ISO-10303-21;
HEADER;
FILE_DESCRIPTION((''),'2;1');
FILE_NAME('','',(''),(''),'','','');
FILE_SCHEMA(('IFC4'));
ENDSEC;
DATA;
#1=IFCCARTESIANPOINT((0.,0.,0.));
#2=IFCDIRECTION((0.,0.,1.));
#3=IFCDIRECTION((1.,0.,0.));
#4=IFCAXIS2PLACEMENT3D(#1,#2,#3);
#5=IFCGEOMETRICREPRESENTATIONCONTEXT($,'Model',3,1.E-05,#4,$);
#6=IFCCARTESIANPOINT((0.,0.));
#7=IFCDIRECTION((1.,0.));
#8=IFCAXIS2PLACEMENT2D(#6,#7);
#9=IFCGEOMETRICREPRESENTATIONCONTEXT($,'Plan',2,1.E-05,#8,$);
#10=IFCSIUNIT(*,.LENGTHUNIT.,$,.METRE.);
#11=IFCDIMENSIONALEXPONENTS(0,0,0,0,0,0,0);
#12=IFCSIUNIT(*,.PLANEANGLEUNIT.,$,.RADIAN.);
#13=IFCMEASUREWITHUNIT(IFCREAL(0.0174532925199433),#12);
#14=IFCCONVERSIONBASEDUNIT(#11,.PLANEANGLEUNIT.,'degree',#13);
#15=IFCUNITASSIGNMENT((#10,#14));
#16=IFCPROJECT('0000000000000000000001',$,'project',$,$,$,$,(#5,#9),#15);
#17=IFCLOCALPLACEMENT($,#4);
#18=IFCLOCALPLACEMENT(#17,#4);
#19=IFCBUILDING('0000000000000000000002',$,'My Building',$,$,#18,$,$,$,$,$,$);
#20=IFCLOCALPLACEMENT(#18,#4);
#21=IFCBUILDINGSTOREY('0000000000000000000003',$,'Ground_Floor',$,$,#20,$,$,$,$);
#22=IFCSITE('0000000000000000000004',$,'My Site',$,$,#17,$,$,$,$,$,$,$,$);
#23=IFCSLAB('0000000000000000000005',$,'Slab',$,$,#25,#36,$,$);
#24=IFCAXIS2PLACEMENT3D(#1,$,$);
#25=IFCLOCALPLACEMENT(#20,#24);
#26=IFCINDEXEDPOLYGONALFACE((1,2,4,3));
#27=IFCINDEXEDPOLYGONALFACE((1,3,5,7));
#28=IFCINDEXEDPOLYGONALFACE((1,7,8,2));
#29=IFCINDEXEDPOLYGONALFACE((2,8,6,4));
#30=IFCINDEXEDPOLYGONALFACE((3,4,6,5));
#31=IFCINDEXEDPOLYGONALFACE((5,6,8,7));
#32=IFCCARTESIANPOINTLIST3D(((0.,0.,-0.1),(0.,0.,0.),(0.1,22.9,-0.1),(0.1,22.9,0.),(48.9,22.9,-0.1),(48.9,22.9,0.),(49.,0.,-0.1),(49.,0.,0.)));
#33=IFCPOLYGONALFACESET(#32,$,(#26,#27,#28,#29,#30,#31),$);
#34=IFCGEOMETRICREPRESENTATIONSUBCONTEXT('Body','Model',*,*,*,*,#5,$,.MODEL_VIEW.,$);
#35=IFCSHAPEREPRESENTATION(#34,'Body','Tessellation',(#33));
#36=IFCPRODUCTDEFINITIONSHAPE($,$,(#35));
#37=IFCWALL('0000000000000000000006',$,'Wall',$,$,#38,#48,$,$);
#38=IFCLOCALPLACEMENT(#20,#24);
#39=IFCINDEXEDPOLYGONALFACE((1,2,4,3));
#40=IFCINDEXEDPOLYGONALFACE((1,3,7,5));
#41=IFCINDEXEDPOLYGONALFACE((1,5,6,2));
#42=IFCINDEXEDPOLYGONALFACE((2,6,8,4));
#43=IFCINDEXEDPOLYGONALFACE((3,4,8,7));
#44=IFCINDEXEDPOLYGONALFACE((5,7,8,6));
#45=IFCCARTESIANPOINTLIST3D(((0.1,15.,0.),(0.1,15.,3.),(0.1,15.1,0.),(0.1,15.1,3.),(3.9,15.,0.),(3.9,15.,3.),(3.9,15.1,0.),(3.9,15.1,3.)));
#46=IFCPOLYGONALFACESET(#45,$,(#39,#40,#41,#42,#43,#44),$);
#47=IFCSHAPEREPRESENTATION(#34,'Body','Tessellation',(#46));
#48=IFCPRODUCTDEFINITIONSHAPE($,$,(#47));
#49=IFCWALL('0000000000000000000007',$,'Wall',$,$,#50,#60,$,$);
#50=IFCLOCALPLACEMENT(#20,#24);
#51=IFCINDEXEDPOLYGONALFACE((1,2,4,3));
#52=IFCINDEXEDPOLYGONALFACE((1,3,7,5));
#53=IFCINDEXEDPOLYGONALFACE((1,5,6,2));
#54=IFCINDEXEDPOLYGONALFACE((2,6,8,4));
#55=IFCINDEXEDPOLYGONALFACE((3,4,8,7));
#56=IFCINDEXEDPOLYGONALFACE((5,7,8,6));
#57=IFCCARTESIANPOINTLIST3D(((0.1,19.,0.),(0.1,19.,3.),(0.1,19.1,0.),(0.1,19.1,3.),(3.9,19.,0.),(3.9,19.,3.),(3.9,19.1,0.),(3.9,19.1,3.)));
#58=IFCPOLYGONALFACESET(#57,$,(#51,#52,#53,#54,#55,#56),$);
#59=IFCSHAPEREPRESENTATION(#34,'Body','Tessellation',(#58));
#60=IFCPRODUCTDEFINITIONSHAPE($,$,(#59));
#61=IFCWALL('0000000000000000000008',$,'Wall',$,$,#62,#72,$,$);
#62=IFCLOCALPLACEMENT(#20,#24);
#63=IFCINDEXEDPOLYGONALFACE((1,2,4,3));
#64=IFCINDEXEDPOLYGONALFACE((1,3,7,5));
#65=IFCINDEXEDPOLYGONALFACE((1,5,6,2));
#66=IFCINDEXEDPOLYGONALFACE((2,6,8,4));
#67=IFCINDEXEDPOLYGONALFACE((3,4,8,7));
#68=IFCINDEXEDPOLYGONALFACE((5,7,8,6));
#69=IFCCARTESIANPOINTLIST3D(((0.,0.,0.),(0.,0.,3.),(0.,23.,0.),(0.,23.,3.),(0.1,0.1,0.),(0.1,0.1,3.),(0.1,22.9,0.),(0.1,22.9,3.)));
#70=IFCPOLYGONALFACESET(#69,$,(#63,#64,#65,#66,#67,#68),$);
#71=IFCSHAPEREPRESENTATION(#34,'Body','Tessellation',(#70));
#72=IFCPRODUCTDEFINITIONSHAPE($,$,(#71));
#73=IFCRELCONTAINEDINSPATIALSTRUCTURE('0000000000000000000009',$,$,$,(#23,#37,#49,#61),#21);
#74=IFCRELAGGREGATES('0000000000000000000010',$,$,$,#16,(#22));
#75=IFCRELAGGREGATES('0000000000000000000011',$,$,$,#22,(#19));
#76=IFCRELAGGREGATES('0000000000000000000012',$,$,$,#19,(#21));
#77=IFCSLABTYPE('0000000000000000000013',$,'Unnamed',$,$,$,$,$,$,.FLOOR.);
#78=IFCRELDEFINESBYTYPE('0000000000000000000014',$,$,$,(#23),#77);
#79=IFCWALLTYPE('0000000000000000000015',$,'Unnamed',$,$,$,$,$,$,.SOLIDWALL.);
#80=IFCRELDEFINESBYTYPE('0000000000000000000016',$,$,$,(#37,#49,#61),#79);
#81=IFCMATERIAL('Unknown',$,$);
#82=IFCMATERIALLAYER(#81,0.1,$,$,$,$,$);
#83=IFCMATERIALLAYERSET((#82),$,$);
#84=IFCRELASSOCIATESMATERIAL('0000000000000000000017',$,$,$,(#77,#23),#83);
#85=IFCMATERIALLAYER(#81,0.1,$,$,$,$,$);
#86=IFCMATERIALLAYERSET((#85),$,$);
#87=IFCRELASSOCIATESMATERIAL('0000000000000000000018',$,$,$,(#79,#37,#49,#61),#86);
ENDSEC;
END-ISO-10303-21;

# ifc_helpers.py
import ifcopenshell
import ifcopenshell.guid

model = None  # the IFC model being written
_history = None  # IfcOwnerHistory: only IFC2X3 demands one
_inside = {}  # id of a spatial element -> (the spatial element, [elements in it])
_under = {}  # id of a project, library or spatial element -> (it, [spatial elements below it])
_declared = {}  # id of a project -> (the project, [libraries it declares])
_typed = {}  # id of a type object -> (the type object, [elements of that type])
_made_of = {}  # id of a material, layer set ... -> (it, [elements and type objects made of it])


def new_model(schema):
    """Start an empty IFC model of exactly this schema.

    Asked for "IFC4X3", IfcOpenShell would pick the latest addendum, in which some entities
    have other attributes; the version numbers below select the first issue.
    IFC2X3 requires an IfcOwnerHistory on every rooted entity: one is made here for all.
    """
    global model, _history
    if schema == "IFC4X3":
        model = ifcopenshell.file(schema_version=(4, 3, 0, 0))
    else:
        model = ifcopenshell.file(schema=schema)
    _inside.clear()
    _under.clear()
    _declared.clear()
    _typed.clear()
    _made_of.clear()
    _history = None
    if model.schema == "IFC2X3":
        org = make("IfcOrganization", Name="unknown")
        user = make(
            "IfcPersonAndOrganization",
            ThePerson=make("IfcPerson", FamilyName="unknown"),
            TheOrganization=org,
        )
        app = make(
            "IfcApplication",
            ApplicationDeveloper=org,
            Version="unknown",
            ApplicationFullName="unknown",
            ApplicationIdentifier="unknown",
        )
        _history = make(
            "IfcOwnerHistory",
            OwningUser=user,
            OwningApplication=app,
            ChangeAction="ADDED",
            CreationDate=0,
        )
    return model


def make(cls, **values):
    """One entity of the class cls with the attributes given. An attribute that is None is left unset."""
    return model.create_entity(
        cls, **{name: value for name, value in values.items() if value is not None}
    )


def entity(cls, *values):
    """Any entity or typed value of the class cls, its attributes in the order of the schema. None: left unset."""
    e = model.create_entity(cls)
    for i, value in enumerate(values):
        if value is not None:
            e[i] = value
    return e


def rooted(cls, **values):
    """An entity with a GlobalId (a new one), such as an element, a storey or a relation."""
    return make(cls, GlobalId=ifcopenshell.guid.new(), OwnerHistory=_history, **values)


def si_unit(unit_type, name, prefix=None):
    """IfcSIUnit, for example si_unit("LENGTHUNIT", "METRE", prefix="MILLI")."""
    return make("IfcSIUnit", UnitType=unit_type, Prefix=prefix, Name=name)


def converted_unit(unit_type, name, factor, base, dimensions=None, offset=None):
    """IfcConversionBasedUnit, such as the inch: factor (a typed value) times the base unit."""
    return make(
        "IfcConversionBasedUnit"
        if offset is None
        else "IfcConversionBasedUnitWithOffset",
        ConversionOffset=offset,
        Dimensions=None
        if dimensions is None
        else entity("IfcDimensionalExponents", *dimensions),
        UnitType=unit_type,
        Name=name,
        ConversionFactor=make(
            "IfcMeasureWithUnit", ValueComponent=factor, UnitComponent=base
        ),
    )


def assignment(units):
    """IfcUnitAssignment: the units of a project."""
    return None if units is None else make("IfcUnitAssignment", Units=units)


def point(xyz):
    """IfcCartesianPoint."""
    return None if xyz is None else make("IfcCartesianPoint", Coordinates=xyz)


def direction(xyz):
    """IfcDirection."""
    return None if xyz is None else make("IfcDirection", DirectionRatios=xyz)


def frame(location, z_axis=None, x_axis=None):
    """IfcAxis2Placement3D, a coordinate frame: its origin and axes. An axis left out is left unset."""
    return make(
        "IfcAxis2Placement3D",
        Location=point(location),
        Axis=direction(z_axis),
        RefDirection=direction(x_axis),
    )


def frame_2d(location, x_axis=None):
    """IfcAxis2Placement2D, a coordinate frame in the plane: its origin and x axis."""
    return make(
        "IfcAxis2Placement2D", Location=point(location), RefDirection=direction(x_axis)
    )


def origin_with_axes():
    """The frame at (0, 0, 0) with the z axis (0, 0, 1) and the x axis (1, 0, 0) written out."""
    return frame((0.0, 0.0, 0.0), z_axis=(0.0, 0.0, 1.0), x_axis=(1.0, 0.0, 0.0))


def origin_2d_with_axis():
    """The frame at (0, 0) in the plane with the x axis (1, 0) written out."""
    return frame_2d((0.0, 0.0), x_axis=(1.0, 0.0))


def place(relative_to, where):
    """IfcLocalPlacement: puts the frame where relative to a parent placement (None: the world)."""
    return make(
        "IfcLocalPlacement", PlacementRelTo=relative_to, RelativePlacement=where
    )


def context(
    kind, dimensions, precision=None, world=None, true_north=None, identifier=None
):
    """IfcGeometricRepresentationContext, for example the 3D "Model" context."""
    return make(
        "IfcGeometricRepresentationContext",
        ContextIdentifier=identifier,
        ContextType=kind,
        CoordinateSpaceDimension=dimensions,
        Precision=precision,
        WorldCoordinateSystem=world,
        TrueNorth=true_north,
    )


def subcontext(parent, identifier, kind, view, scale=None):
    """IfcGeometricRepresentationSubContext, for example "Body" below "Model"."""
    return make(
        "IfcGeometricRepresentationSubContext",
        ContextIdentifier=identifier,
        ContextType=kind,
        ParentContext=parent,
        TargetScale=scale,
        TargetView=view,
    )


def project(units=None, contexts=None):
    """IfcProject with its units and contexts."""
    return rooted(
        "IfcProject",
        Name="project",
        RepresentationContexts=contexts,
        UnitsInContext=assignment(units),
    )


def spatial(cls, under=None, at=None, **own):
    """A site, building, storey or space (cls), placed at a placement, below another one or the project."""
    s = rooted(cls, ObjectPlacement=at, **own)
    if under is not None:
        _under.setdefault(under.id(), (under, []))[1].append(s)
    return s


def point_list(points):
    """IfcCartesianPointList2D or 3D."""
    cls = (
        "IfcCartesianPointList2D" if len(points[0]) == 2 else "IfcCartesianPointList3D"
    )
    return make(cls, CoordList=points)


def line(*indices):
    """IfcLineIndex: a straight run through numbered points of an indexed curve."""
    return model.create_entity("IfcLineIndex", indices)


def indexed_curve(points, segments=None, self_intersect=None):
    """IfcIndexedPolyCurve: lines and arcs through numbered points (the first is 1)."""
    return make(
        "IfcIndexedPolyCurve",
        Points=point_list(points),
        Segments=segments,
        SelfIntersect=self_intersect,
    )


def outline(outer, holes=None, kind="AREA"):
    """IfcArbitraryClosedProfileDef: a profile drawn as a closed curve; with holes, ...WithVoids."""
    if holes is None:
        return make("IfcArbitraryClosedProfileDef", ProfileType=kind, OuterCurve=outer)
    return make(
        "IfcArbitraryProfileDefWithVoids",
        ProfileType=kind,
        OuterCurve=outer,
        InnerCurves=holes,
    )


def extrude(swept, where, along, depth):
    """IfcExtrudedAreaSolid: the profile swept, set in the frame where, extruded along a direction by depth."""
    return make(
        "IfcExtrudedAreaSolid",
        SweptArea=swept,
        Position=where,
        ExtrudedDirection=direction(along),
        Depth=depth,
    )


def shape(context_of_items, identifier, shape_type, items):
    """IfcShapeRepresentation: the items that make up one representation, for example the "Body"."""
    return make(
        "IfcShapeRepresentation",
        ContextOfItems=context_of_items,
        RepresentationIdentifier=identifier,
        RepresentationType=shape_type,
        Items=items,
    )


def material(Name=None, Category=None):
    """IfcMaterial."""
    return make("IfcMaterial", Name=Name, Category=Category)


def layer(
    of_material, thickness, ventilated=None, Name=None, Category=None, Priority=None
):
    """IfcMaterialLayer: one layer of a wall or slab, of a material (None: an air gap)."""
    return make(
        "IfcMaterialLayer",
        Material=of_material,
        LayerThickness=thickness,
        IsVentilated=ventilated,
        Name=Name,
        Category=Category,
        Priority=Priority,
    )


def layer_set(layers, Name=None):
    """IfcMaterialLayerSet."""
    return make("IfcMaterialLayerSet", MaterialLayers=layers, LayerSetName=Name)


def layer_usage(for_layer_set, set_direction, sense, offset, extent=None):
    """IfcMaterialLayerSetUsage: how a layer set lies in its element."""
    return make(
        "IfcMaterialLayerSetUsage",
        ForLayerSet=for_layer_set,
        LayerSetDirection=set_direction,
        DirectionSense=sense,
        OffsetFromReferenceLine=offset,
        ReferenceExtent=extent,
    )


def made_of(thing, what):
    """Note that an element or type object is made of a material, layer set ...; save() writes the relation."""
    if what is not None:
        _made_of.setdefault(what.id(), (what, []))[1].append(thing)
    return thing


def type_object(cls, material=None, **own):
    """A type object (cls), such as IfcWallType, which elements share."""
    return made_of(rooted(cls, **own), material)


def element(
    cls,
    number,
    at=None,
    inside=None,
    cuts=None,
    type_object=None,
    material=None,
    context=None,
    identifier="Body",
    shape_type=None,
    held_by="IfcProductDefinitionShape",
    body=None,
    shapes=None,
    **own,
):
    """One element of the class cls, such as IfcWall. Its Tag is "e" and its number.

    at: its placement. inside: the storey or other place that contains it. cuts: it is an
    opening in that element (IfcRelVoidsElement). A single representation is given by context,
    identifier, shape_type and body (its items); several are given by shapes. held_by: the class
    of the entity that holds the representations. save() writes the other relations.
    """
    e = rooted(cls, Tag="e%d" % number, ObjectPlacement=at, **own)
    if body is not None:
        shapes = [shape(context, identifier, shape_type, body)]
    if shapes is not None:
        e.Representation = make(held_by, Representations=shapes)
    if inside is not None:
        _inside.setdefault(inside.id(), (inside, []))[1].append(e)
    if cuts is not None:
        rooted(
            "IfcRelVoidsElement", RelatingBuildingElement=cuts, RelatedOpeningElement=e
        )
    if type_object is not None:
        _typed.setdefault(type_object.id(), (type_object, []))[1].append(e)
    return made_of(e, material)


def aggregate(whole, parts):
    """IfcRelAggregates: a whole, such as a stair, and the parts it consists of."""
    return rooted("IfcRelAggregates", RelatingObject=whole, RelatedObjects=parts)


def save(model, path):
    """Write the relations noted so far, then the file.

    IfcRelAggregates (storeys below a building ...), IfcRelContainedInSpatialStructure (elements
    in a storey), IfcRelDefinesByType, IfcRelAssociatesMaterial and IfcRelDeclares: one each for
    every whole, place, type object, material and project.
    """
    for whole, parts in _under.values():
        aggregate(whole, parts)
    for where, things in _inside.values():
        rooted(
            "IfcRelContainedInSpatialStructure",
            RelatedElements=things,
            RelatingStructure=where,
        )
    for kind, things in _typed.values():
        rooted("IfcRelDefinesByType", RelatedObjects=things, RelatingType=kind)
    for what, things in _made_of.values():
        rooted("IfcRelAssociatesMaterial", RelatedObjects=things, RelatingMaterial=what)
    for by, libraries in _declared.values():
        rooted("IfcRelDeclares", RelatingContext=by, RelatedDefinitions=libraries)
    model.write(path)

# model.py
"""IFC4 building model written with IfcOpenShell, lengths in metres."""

from ifc_helpers import new_model, entity, si_unit, converted_unit, frame, origin_with_axes, origin_2d_with_axis, place, context, subcontext, project, spatial, line, indexed_curve, outline, extrude, material, layer, layer_set, layer_usage, type_object, element, save


model = new_model("IFC4")

# Units and contexts
model_context = context("Model", 3, precision=1e-05, world=origin_with_axes())
plan_context = context("Plan", 2, precision=1e-05, world=origin_2d_with_axis())
body_context_1 = subcontext(model_context, "Body", "Model", "MODEL_VIEW")
ifc_project = project(units=[si_unit("LENGTHUNIT", "METRE"), converted_unit("PLANEANGLEUNIT", "degree", entity("IfcReal", 0.0174532925199433), si_unit("PLANEANGLEUNIT", "RADIAN"), dimensions=[0, 0, 0, 0, 0, 0, 0])], contexts=[model_context, plan_context])

# Site, building, storey
site_placement = place(None, origin_with_axes())
site = spatial("IfcSite", under=ifc_project, at=site_placement, Name="My Site")
building_placement = place(site_placement, origin_with_axes())
building = spatial("IfcBuilding", under=site, at=building_placement, Name="My Building")
storey_placement = place(building_placement, origin_with_axes())
storey = spatial("IfcBuildingStorey", under=building, at=storey_placement, Name="Ground_Floor")

# Slab
ifc_material = material(Name="Unknown")
ifc_layer_1 = layer(ifc_material, 0.1)
ifc_layer_set_1 = layer_set([ifc_layer_1])
ifc_layer_usage_1 = layer_usage(ifc_layer_set_1, "AXIS3", "POSITIVE", -0.1)
slab_type = type_object("IfcSlabType", Name="Unnamed", PredefinedType="FLOOR", material=ifc_layer_set_1)
slab_placement = place(storey_placement, frame((0.1, 22.9, 0.0), z_axis=(0.0, 0.0, 1.0), x_axis=(1.0, 0.0, 0.0)))
element("IfcSlab", 1, at=slab_placement, inside=storey, type_object=slab_type, material=ifc_layer_usage_1, Name="Slab", context=body_context_1, shape_type="SweptSolid", body=[
    extrude(outline(indexed_curve([(0.0, 0.0), (48.8, 0.0), (48.9, -22.9), (-0.1, -22.9), (0.0, 0.0)])), frame((0.0, 0.0, -0.1), z_axis=(0.0, 0.0, 1.0), x_axis=(1.0, 0.0, 0.0)), (0.0, 0.0, 1.0), 0.1),
])

# Shared definitions
ifc_layer_2 = layer(ifc_material, 0.1)
ifc_layer_set_2 = layer_set([ifc_layer_2])
wall_type = type_object("IfcWallType", Name="Unnamed", PredefinedType="SOLIDWALL", material=ifc_layer_set_2)

# Walls
ifc_layer_usage_2 = layer_usage(ifc_layer_set_2, "AXIS2", "POSITIVE", 0.0)
wall_1_placement = place(storey_placement, frame((0.0, 15.0, 0.0), z_axis=(0.0, 0.0, 1.0), x_axis=(1.0, 0.0, 0.0)))
element("IfcWall", 2, at=wall_1_placement, inside=storey, type_object=wall_type, material=ifc_layer_usage_2, Name="Wall", context=body_context_1, shape_type="SweptSolid", body=[
    extrude(outline(indexed_curve([(0.1, 0.0), (0.1, 0.1), (3.9, 0.1), (3.9, 0.0)], segments=[line(1, 2, 3, 4, 1)])), origin_with_axes(), (0.0, 0.0, 1.0), 3.0),
])
ifc_layer_usage_3 = layer_usage(ifc_layer_set_2, "AXIS2", "POSITIVE", 0.0)
wall_2_placement = place(storey_placement, frame((0.0, 19.0, 0.0), z_axis=(0.0, 0.0, 1.0), x_axis=(1.0, 0.0, 0.0)))
element("IfcWall", 3, at=wall_2_placement, inside=storey, type_object=wall_type, material=ifc_layer_usage_3, Name="Wall", context=body_context_1, shape_type="SweptSolid", body=[
    extrude(outline(indexed_curve([(0.1, 0.0), (0.1, 0.1), (3.9, 0.1), (3.9, 0.0)], segments=[line(1, 2, 3, 4, 1)])), origin_with_axes(), (0.0, 0.0, 1.0), 3.0),
])
ifc_layer_usage_4 = layer_usage(ifc_layer_set_2, "AXIS2", "POSITIVE", 0.0)
wall_3_placement = place(storey_placement, frame((0.0, 23.0, 0.0), z_axis=(0.0, 0.0, 1.0), x_axis=(0.0, -1.0, 0.0)))
element("IfcWall", 4, at=wall_3_placement, inside=storey, type_object=wall_type, material=ifc_layer_usage_4, Name="Wall", context=body_context_1, shape_type="SweptSolid", body=[
    extrude(outline(indexed_curve([(0.0, 0.0), (0.1, 0.1), (22.9, 0.1), (23.0, 0.0)], segments=[line(1, 2, 3, 4, 1)])), origin_with_axes(), (0.0, 0.0, 1.0), 3.0),
])

save(model, "model.ifc")
